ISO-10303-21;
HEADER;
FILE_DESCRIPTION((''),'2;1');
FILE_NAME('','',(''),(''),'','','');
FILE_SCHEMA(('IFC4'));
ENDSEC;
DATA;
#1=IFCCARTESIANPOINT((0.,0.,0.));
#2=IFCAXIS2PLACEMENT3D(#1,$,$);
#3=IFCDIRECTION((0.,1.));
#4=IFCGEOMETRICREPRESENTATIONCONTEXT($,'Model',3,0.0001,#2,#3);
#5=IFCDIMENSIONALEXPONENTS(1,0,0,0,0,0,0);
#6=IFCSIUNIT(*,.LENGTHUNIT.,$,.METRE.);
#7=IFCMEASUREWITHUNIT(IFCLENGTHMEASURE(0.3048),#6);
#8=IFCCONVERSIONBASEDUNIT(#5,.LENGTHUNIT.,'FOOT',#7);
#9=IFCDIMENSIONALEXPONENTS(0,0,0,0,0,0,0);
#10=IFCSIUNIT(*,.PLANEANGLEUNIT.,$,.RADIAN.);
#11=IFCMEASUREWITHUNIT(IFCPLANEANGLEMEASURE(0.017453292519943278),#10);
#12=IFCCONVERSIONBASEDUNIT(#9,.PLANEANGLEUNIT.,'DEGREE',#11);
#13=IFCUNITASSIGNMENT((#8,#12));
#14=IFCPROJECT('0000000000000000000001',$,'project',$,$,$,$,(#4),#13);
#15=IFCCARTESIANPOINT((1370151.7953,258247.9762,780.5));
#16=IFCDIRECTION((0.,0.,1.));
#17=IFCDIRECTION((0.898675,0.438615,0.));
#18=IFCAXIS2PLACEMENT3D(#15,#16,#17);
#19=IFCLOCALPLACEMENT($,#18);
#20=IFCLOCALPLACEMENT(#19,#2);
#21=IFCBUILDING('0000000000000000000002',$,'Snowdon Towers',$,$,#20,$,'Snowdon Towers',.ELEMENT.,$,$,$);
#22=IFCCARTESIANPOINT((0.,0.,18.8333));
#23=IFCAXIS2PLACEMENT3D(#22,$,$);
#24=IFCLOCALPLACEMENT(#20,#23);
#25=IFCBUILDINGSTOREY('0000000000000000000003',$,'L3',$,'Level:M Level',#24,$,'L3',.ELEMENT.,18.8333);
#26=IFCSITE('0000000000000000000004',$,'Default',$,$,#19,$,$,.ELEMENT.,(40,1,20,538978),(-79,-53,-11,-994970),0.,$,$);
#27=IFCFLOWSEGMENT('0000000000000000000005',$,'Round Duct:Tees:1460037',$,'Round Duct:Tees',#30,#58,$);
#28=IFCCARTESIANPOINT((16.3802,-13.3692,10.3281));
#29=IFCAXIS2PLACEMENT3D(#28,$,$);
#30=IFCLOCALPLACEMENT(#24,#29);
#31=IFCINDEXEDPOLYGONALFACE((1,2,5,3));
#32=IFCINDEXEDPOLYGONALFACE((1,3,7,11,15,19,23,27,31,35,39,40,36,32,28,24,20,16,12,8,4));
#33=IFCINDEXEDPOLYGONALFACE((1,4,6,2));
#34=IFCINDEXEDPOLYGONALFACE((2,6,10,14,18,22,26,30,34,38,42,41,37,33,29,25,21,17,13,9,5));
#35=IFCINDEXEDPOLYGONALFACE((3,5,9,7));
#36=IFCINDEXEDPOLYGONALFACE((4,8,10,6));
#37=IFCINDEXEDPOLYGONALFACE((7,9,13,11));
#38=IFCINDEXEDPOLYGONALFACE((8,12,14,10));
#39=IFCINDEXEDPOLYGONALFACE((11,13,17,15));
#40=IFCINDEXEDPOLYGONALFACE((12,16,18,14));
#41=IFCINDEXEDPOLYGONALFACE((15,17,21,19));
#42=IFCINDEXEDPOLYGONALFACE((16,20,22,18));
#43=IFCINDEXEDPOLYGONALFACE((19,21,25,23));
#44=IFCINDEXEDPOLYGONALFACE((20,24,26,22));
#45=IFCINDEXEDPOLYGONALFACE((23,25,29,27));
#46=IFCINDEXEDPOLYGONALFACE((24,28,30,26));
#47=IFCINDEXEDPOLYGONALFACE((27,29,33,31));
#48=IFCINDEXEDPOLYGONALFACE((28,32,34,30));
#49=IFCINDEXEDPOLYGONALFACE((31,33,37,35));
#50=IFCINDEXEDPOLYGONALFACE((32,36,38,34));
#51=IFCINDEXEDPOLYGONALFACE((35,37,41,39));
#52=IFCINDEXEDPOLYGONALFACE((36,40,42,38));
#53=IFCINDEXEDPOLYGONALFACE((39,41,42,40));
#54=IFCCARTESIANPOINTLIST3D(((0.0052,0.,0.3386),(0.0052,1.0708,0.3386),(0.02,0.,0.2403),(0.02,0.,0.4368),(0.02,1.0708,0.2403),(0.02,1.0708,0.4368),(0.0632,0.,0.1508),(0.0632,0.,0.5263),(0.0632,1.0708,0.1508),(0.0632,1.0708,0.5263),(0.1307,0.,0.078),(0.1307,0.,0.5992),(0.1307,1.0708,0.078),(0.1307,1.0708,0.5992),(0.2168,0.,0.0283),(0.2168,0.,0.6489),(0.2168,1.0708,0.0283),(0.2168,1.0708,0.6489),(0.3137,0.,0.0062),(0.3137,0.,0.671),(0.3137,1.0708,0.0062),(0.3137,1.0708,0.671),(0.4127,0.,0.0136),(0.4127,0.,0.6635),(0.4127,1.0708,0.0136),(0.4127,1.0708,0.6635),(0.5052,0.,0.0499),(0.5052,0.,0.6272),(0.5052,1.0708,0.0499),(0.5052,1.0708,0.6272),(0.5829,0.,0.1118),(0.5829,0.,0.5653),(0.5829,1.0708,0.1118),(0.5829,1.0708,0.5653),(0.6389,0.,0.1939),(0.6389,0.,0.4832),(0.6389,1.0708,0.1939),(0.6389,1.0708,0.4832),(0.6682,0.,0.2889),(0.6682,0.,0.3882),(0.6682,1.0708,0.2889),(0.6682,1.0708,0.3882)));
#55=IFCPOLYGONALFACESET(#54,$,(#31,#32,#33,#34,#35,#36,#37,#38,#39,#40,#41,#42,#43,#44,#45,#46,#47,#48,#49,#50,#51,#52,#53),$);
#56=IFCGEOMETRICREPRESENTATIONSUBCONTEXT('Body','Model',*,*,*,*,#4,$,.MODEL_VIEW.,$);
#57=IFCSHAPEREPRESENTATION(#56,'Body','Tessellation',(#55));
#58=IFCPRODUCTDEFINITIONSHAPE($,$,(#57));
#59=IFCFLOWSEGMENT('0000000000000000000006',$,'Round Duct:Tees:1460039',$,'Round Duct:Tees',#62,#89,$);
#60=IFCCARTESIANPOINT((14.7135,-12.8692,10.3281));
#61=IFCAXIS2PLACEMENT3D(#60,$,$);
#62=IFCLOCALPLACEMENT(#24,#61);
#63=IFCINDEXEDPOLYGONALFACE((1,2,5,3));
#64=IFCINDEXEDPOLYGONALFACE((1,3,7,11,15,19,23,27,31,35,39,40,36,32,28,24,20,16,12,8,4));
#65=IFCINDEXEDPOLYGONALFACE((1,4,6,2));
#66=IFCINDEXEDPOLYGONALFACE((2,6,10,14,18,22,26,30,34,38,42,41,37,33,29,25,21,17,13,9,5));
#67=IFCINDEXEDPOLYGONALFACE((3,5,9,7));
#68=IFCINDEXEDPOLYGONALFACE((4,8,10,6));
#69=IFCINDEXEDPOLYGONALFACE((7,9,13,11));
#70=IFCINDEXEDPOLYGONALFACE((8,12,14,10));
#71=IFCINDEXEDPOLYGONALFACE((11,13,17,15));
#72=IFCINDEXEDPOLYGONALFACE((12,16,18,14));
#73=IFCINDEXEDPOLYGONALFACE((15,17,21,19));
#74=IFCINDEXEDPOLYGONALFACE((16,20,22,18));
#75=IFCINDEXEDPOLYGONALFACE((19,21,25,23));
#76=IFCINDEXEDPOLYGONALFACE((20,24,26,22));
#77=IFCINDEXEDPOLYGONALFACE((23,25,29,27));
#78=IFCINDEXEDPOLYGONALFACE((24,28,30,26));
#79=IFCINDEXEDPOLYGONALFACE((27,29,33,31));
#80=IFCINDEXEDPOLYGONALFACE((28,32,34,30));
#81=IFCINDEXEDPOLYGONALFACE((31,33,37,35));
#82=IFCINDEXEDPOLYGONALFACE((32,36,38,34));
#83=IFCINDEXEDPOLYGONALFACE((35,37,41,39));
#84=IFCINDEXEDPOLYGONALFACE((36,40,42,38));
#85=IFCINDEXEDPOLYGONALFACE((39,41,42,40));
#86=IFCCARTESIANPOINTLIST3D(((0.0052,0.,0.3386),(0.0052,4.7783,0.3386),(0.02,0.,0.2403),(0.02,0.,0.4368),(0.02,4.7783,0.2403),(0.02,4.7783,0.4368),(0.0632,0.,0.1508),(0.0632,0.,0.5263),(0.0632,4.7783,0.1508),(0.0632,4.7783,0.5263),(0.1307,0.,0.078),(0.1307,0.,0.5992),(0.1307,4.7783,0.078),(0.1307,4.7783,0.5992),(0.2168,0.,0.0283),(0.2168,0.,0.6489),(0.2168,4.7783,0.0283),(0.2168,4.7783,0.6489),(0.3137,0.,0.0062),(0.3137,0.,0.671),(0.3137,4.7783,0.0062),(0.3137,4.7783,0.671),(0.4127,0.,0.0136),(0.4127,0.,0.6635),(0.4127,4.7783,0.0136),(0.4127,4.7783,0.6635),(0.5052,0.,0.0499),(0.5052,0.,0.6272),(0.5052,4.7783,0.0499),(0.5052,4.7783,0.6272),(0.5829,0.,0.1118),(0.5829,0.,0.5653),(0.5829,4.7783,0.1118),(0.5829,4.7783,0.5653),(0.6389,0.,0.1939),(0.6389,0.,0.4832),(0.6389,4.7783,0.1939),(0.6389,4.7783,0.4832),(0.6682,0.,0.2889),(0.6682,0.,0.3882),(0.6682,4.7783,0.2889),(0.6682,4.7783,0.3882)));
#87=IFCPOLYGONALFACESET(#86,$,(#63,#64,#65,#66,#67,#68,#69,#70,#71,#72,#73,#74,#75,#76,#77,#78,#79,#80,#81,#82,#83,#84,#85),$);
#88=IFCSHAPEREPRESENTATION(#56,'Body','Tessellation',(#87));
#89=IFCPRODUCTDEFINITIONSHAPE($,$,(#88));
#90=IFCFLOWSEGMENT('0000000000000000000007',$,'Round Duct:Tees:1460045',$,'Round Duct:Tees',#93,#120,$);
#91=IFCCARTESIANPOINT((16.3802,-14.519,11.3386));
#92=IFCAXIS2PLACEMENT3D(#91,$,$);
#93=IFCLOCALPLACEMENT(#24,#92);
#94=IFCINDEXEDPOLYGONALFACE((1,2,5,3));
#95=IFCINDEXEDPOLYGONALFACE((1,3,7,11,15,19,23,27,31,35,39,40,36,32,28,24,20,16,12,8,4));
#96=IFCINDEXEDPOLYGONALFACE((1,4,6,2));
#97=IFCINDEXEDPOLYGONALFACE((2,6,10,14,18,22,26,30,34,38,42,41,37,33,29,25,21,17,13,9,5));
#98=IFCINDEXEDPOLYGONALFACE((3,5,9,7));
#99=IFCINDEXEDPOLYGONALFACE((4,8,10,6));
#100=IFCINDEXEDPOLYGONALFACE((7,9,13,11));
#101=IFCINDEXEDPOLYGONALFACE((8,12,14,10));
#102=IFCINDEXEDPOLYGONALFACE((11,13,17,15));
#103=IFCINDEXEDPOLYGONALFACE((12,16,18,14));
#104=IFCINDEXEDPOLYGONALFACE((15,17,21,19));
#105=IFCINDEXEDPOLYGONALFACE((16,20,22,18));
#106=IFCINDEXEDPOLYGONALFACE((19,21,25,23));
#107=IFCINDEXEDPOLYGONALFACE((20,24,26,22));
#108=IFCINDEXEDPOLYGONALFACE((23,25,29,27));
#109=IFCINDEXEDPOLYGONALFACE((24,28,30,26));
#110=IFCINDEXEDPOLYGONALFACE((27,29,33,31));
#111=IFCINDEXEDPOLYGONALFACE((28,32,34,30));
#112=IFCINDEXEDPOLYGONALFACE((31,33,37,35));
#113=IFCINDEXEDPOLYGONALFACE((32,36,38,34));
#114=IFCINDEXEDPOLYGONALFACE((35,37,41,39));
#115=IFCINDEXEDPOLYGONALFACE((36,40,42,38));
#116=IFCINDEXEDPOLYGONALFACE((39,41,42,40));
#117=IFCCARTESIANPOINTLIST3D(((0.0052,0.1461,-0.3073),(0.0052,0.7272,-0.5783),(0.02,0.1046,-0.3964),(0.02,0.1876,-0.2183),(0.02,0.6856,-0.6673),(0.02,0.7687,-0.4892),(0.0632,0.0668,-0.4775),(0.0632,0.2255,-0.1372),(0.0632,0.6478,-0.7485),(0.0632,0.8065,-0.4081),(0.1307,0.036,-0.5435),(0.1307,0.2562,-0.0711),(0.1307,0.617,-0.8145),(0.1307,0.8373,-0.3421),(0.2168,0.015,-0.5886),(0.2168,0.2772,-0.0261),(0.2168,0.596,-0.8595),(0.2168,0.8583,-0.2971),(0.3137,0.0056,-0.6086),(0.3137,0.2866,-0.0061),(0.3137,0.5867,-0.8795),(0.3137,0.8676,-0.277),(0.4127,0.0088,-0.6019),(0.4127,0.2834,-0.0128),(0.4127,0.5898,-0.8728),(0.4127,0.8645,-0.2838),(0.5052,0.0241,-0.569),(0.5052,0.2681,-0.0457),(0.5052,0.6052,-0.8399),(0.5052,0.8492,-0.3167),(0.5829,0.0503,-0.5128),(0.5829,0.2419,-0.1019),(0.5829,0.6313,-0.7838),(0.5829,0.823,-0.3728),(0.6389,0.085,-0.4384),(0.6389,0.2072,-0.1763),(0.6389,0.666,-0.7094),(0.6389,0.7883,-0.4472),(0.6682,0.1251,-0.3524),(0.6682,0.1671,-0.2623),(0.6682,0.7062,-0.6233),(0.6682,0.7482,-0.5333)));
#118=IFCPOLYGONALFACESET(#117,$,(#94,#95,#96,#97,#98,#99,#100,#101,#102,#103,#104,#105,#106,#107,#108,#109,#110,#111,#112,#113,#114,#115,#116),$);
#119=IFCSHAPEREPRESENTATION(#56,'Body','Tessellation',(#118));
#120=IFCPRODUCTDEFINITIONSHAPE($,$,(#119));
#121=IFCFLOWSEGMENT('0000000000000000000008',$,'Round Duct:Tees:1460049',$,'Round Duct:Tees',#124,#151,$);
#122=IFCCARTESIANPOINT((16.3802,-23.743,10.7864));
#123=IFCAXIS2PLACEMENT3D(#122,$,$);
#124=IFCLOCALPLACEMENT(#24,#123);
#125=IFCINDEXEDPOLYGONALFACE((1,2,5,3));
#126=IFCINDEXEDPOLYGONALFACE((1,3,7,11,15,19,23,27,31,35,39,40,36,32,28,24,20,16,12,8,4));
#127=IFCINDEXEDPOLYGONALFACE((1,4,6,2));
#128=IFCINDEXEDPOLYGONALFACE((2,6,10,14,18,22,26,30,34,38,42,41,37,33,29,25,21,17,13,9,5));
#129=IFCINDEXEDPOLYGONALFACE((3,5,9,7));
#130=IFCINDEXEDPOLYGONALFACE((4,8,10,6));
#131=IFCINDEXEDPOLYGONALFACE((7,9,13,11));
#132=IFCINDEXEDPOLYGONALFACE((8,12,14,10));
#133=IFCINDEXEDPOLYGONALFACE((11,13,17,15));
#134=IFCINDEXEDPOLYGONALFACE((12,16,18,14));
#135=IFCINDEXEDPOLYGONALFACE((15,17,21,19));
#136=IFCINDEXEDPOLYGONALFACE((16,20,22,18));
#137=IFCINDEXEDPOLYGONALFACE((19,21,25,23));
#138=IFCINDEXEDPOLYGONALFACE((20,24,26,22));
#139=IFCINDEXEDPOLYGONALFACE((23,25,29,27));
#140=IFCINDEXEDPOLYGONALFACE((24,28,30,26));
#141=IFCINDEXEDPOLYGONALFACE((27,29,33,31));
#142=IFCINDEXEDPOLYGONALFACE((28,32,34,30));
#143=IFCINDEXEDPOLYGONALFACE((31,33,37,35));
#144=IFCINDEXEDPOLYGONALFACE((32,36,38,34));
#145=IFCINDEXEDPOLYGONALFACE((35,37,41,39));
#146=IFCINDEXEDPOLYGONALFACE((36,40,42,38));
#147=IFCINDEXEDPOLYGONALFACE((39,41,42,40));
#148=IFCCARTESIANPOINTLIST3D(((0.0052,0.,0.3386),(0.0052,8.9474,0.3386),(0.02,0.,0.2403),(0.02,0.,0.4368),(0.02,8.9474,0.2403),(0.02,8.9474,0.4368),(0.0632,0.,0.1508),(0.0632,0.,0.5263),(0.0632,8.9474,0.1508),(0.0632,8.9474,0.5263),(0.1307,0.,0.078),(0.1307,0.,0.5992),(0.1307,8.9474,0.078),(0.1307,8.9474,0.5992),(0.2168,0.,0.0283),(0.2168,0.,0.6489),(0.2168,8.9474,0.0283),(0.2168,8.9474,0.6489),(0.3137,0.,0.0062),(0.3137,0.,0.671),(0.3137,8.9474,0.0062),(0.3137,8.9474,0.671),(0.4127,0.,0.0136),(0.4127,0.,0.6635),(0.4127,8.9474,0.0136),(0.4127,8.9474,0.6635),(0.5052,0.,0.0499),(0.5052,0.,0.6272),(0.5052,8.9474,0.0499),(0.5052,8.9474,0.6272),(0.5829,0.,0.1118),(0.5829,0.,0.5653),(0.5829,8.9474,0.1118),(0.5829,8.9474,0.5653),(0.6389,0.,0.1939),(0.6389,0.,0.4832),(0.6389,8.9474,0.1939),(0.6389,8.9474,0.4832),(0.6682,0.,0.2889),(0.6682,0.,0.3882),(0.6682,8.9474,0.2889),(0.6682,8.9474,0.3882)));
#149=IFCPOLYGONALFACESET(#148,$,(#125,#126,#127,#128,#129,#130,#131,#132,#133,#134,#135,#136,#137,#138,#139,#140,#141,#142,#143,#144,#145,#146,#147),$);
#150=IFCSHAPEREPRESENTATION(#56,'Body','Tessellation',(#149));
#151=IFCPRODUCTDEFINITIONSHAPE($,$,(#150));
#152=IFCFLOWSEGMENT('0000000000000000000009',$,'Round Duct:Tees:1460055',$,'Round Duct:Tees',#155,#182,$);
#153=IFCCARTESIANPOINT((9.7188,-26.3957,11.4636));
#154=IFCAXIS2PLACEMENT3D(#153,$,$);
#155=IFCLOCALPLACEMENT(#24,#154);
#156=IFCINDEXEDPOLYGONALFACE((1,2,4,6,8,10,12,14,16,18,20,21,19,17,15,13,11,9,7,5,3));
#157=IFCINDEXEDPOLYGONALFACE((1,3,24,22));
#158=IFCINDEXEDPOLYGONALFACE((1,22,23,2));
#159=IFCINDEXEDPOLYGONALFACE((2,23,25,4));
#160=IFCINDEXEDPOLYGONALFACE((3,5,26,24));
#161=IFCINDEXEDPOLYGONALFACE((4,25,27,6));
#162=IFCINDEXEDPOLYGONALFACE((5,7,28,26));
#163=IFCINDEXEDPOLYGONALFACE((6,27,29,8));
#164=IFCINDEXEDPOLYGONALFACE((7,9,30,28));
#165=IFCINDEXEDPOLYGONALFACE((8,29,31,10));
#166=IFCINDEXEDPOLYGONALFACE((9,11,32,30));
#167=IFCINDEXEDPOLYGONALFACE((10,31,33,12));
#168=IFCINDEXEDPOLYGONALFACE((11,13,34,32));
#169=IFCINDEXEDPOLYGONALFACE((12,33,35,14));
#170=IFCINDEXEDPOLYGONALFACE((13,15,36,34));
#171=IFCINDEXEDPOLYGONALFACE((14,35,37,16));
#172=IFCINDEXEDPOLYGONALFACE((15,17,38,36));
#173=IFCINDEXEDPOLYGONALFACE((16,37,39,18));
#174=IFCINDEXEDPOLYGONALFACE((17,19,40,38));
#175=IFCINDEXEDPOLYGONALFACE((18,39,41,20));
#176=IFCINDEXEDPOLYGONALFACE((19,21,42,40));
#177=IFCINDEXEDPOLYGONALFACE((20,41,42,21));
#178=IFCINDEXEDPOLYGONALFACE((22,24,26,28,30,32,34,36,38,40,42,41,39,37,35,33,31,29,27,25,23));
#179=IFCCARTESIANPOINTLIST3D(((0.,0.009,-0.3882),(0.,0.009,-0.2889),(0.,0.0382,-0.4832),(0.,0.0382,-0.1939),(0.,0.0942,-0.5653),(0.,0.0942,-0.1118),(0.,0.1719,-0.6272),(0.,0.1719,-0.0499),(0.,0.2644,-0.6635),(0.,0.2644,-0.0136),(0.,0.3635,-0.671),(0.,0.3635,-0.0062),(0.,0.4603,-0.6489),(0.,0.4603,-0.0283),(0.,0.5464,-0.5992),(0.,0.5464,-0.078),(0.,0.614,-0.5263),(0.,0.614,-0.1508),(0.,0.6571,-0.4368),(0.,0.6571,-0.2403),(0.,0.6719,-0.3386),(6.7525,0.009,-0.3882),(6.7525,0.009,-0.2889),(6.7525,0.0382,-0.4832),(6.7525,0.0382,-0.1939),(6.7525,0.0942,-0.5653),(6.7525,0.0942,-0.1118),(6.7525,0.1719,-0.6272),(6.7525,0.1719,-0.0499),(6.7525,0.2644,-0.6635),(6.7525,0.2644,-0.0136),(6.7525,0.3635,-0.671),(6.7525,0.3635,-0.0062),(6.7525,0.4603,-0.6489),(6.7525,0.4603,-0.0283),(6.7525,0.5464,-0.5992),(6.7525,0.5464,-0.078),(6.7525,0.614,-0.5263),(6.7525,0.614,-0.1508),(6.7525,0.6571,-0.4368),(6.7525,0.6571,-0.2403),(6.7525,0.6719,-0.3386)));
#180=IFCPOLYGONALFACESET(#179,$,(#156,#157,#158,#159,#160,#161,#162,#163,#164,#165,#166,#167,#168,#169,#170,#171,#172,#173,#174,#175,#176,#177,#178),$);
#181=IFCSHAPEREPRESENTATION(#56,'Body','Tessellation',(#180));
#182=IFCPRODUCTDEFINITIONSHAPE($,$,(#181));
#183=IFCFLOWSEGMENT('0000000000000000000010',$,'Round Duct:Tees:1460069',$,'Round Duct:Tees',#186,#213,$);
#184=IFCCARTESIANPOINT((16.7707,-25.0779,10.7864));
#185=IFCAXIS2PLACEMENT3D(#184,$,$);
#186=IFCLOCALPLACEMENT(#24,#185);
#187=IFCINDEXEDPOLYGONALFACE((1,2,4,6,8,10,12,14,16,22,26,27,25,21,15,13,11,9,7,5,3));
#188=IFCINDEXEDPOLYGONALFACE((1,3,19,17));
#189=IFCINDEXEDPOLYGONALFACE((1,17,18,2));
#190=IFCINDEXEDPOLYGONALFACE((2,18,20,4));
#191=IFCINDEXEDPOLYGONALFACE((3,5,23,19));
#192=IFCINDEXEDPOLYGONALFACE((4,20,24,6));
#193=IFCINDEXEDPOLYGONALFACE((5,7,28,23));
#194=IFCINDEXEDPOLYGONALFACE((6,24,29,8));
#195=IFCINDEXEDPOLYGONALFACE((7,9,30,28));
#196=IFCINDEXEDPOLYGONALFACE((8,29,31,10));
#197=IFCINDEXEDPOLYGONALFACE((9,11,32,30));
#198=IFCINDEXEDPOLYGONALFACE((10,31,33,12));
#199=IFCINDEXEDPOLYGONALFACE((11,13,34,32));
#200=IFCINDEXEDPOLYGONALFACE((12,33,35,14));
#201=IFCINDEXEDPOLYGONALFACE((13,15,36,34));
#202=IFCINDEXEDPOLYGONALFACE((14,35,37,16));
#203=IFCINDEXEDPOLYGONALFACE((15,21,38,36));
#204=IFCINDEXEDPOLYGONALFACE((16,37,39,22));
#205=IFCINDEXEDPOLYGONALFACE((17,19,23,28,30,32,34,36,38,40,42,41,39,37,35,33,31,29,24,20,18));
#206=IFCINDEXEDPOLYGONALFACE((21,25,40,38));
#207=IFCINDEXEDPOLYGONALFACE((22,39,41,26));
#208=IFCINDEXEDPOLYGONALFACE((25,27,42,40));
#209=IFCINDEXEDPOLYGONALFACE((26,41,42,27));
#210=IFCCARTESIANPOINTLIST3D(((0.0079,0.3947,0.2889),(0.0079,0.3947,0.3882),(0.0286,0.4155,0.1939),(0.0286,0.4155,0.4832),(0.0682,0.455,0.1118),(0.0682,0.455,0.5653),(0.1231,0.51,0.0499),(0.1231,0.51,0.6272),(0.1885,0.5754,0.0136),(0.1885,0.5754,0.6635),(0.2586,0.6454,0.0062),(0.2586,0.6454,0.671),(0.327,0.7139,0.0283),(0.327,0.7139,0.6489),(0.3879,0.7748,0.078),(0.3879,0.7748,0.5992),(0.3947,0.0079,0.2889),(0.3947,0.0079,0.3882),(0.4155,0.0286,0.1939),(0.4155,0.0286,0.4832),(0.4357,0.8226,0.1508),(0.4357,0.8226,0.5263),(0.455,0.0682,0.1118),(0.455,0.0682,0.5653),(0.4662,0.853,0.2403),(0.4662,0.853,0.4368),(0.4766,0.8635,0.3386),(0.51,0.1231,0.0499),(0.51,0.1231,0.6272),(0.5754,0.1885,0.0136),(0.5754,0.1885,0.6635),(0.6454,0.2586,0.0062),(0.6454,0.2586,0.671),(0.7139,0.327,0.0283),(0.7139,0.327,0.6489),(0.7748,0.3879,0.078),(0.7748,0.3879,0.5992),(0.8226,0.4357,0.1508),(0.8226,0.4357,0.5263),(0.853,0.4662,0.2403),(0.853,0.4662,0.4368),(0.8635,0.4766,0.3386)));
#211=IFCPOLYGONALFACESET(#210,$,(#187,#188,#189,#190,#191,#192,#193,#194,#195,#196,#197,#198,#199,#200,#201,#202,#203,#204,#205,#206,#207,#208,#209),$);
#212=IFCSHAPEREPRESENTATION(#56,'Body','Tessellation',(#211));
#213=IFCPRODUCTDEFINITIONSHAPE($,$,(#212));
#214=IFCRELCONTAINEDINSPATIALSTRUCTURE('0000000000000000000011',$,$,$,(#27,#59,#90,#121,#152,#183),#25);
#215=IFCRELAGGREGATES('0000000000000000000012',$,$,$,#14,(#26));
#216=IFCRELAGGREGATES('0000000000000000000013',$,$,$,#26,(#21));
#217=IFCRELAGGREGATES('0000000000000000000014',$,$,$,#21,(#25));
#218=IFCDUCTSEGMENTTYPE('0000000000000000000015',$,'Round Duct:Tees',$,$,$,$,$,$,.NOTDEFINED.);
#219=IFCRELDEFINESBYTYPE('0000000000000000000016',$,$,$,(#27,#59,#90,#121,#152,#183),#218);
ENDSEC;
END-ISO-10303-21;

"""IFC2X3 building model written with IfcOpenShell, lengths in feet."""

from ifc_helpers import new_model, entity, si_unit, converted_unit, direction, frame, frame_2d, origin, origin_2d_with_axis, place, context, subcontext, project, spatial, circle, extrude, type_object, element, save


model = new_model("IFC2X3")

# Units and contexts
model_context = context("Model", 3, precision=0.0001, world=origin(), true_north=direction((0.0, 1.0)))
body_context = subcontext(model_context, "Body", "Model", "MODEL_VIEW")
ifc_project = project(units=[converted_unit("LENGTHUNIT", "FOOT", entity("IfcLengthMeasure", 0.3048), si_unit("LENGTHUNIT", "METRE"), dimensions=[1, 0, 0, 0, 0, 0, 0]), converted_unit("PLANEANGLEUNIT", "DEGREE", entity("IfcPlaneAngleMeasure", 0.017453292519943278), si_unit("PLANEANGLEUNIT", "RADIAN"), dimensions=[0, 0, 0, 0, 0, 0, 0])], contexts=[model_context])

# Site, building, storey
site_placement = place(None, frame((1370151.7953, 258247.9762, 780.5), z_axis=(0.0, 0.0, 1.0), x_axis=(0.898675, 0.438615, 0.0)))
site = spatial("IfcSite", under=ifc_project, at=site_placement, Name="Default", CompositionType="ELEMENT", RefLatitude=(40, 1, 20, 538978), RefLongitude=(-79, -53, -11, -994970), RefElevation=0.0)
building_placement = place(site_placement, origin())
building = spatial("IfcBuilding", under=site, at=building_placement, Name="Snowdon Towers", LongName="Snowdon Towers", CompositionType="ELEMENT")
storey_placement = place(building_placement, frame((0.0, 0.0, 18.8333)))
storey = spatial("IfcBuildingStorey", under=building, at=storey_placement, Name="L3", ObjectType="Level:M Level", LongName="L3", CompositionType="ELEMENT", Elevation=18.8333)

# Flow segments
duct_segment_type = type_object("IfcDuctSegmentType", Name="Round Duct:Tees", PredefinedType="NOTDEFINED")
flow_segment_1_placement = place(storey_placement, frame((16.3802, -13.3692, 10.3281)))
element("IfcFlowSegment", 1, at=flow_segment_1_placement, inside=storey, type_object=duct_segment_type, Name="Round Duct:Tees:1460037", ObjectType="Round Duct:Tees", context=body_context, shape_type="SweptSolid", body=[
    extrude(circle(Radius=0.3333, at=frame_2d((0.0, 0.0), x_axis=(1.0, 0.0))), frame((0.3386, 0.0, 0.3386), z_axis=(0.0, 1.0, 0.0), x_axis=(-1.0, 0.0, 0.0)), (0.0, 0.0, 1.0), 1.0708),
])
flow_segment_2_placement = place(storey_placement, frame((14.7135, -12.8692, 10.3281)))
element("IfcFlowSegment", 2, at=flow_segment_2_placement, inside=storey, type_object=duct_segment_type, Name="Round Duct:Tees:1460039", ObjectType="Round Duct:Tees", context=body_context, shape_type="SweptSolid", body=[
    extrude(circle(Radius=0.3333, at=frame_2d((0.0, 0.0), x_axis=(1.0, 0.0))), frame((0.3386, 0.0, 0.3386), z_axis=(0.0, 1.0, 0.0), x_axis=(-1.0, 0.0, 0.0)), (0.0, 0.0, 1.0), 4.7783),
])
flow_segment_3_placement = place(storey_placement, frame((16.3802, -14.519, 11.3386)))
element("IfcFlowSegment", 3, at=flow_segment_3_placement, inside=storey, type_object=duct_segment_type, Name="Round Duct:Tees:1460045", ObjectType="Round Duct:Tees", context=body_context, shape_type="SweptSolid", body=[
    extrude(circle(Radius=0.3333, at=frame_2d((0.0, 0.0), x_axis=(1.0, 0.0))), frame((0.3386, 0.7272, -0.5783), z_axis=(0.0, -0.906308, 0.422618), x_axis=(-1.0, 0.0, 0.0)), (0.0, 0.0, 1.0), 0.6411),
])
flow_segment_4_placement = place(storey_placement, frame((16.3802, -23.743, 10.7864)))
element("IfcFlowSegment", 4, at=flow_segment_4_placement, inside=storey, type_object=duct_segment_type, Name="Round Duct:Tees:1460049", ObjectType="Round Duct:Tees", context=body_context, shape_type="SweptSolid", body=[
    extrude(circle(Radius=0.3333, at=frame_2d((0.0, 0.0), x_axis=(1.0, 0.0))), frame((0.3386, 0.0, 0.3386), z_axis=(0.0, 1.0, 0.0), x_axis=(-1.0, 0.0, 0.0)), (0.0, 0.0, 1.0), 8.9474),
])
flow_segment_5_placement = place(storey_placement, frame((9.7188, -26.3957, 11.4636)))
element("IfcFlowSegment", 5, at=flow_segment_5_placement, inside=storey, type_object=duct_segment_type, Name="Round Duct:Tees:1460055", ObjectType="Round Duct:Tees", context=body_context, shape_type="SweptSolid", body=[
    extrude(circle(Radius=0.3333, at=frame_2d((0.0, 0.0), x_axis=(1.0, 0.0))), frame((0.0, 0.3386, -0.3386), z_axis=(1.0, 0.0, 0.0), x_axis=(0.0, 1.0, 0.0)), (0.0, 0.0, 1.0), 6.7525),
])
flow_segment_6_placement = place(storey_placement, frame((16.7707, -25.0779, 10.7864)))
element("IfcFlowSegment", 6, at=flow_segment_6_placement, inside=storey, type_object=duct_segment_type, Name="Round Duct:Tees:1460069", ObjectType="Round Duct:Tees", context=body_context, shape_type="SweptSolid", body=[
    extrude(circle(Radius=0.3333, at=origin_2d_with_axis()), frame((0.2409, 0.6278, 0.3386), z_axis=(0.707107, -0.707107, 0.0), x_axis=(0.707107, 0.707107, 0.0)), (0.0, 0.0, 1.0), 0.5471),
])

save(model, "model.ifc")
